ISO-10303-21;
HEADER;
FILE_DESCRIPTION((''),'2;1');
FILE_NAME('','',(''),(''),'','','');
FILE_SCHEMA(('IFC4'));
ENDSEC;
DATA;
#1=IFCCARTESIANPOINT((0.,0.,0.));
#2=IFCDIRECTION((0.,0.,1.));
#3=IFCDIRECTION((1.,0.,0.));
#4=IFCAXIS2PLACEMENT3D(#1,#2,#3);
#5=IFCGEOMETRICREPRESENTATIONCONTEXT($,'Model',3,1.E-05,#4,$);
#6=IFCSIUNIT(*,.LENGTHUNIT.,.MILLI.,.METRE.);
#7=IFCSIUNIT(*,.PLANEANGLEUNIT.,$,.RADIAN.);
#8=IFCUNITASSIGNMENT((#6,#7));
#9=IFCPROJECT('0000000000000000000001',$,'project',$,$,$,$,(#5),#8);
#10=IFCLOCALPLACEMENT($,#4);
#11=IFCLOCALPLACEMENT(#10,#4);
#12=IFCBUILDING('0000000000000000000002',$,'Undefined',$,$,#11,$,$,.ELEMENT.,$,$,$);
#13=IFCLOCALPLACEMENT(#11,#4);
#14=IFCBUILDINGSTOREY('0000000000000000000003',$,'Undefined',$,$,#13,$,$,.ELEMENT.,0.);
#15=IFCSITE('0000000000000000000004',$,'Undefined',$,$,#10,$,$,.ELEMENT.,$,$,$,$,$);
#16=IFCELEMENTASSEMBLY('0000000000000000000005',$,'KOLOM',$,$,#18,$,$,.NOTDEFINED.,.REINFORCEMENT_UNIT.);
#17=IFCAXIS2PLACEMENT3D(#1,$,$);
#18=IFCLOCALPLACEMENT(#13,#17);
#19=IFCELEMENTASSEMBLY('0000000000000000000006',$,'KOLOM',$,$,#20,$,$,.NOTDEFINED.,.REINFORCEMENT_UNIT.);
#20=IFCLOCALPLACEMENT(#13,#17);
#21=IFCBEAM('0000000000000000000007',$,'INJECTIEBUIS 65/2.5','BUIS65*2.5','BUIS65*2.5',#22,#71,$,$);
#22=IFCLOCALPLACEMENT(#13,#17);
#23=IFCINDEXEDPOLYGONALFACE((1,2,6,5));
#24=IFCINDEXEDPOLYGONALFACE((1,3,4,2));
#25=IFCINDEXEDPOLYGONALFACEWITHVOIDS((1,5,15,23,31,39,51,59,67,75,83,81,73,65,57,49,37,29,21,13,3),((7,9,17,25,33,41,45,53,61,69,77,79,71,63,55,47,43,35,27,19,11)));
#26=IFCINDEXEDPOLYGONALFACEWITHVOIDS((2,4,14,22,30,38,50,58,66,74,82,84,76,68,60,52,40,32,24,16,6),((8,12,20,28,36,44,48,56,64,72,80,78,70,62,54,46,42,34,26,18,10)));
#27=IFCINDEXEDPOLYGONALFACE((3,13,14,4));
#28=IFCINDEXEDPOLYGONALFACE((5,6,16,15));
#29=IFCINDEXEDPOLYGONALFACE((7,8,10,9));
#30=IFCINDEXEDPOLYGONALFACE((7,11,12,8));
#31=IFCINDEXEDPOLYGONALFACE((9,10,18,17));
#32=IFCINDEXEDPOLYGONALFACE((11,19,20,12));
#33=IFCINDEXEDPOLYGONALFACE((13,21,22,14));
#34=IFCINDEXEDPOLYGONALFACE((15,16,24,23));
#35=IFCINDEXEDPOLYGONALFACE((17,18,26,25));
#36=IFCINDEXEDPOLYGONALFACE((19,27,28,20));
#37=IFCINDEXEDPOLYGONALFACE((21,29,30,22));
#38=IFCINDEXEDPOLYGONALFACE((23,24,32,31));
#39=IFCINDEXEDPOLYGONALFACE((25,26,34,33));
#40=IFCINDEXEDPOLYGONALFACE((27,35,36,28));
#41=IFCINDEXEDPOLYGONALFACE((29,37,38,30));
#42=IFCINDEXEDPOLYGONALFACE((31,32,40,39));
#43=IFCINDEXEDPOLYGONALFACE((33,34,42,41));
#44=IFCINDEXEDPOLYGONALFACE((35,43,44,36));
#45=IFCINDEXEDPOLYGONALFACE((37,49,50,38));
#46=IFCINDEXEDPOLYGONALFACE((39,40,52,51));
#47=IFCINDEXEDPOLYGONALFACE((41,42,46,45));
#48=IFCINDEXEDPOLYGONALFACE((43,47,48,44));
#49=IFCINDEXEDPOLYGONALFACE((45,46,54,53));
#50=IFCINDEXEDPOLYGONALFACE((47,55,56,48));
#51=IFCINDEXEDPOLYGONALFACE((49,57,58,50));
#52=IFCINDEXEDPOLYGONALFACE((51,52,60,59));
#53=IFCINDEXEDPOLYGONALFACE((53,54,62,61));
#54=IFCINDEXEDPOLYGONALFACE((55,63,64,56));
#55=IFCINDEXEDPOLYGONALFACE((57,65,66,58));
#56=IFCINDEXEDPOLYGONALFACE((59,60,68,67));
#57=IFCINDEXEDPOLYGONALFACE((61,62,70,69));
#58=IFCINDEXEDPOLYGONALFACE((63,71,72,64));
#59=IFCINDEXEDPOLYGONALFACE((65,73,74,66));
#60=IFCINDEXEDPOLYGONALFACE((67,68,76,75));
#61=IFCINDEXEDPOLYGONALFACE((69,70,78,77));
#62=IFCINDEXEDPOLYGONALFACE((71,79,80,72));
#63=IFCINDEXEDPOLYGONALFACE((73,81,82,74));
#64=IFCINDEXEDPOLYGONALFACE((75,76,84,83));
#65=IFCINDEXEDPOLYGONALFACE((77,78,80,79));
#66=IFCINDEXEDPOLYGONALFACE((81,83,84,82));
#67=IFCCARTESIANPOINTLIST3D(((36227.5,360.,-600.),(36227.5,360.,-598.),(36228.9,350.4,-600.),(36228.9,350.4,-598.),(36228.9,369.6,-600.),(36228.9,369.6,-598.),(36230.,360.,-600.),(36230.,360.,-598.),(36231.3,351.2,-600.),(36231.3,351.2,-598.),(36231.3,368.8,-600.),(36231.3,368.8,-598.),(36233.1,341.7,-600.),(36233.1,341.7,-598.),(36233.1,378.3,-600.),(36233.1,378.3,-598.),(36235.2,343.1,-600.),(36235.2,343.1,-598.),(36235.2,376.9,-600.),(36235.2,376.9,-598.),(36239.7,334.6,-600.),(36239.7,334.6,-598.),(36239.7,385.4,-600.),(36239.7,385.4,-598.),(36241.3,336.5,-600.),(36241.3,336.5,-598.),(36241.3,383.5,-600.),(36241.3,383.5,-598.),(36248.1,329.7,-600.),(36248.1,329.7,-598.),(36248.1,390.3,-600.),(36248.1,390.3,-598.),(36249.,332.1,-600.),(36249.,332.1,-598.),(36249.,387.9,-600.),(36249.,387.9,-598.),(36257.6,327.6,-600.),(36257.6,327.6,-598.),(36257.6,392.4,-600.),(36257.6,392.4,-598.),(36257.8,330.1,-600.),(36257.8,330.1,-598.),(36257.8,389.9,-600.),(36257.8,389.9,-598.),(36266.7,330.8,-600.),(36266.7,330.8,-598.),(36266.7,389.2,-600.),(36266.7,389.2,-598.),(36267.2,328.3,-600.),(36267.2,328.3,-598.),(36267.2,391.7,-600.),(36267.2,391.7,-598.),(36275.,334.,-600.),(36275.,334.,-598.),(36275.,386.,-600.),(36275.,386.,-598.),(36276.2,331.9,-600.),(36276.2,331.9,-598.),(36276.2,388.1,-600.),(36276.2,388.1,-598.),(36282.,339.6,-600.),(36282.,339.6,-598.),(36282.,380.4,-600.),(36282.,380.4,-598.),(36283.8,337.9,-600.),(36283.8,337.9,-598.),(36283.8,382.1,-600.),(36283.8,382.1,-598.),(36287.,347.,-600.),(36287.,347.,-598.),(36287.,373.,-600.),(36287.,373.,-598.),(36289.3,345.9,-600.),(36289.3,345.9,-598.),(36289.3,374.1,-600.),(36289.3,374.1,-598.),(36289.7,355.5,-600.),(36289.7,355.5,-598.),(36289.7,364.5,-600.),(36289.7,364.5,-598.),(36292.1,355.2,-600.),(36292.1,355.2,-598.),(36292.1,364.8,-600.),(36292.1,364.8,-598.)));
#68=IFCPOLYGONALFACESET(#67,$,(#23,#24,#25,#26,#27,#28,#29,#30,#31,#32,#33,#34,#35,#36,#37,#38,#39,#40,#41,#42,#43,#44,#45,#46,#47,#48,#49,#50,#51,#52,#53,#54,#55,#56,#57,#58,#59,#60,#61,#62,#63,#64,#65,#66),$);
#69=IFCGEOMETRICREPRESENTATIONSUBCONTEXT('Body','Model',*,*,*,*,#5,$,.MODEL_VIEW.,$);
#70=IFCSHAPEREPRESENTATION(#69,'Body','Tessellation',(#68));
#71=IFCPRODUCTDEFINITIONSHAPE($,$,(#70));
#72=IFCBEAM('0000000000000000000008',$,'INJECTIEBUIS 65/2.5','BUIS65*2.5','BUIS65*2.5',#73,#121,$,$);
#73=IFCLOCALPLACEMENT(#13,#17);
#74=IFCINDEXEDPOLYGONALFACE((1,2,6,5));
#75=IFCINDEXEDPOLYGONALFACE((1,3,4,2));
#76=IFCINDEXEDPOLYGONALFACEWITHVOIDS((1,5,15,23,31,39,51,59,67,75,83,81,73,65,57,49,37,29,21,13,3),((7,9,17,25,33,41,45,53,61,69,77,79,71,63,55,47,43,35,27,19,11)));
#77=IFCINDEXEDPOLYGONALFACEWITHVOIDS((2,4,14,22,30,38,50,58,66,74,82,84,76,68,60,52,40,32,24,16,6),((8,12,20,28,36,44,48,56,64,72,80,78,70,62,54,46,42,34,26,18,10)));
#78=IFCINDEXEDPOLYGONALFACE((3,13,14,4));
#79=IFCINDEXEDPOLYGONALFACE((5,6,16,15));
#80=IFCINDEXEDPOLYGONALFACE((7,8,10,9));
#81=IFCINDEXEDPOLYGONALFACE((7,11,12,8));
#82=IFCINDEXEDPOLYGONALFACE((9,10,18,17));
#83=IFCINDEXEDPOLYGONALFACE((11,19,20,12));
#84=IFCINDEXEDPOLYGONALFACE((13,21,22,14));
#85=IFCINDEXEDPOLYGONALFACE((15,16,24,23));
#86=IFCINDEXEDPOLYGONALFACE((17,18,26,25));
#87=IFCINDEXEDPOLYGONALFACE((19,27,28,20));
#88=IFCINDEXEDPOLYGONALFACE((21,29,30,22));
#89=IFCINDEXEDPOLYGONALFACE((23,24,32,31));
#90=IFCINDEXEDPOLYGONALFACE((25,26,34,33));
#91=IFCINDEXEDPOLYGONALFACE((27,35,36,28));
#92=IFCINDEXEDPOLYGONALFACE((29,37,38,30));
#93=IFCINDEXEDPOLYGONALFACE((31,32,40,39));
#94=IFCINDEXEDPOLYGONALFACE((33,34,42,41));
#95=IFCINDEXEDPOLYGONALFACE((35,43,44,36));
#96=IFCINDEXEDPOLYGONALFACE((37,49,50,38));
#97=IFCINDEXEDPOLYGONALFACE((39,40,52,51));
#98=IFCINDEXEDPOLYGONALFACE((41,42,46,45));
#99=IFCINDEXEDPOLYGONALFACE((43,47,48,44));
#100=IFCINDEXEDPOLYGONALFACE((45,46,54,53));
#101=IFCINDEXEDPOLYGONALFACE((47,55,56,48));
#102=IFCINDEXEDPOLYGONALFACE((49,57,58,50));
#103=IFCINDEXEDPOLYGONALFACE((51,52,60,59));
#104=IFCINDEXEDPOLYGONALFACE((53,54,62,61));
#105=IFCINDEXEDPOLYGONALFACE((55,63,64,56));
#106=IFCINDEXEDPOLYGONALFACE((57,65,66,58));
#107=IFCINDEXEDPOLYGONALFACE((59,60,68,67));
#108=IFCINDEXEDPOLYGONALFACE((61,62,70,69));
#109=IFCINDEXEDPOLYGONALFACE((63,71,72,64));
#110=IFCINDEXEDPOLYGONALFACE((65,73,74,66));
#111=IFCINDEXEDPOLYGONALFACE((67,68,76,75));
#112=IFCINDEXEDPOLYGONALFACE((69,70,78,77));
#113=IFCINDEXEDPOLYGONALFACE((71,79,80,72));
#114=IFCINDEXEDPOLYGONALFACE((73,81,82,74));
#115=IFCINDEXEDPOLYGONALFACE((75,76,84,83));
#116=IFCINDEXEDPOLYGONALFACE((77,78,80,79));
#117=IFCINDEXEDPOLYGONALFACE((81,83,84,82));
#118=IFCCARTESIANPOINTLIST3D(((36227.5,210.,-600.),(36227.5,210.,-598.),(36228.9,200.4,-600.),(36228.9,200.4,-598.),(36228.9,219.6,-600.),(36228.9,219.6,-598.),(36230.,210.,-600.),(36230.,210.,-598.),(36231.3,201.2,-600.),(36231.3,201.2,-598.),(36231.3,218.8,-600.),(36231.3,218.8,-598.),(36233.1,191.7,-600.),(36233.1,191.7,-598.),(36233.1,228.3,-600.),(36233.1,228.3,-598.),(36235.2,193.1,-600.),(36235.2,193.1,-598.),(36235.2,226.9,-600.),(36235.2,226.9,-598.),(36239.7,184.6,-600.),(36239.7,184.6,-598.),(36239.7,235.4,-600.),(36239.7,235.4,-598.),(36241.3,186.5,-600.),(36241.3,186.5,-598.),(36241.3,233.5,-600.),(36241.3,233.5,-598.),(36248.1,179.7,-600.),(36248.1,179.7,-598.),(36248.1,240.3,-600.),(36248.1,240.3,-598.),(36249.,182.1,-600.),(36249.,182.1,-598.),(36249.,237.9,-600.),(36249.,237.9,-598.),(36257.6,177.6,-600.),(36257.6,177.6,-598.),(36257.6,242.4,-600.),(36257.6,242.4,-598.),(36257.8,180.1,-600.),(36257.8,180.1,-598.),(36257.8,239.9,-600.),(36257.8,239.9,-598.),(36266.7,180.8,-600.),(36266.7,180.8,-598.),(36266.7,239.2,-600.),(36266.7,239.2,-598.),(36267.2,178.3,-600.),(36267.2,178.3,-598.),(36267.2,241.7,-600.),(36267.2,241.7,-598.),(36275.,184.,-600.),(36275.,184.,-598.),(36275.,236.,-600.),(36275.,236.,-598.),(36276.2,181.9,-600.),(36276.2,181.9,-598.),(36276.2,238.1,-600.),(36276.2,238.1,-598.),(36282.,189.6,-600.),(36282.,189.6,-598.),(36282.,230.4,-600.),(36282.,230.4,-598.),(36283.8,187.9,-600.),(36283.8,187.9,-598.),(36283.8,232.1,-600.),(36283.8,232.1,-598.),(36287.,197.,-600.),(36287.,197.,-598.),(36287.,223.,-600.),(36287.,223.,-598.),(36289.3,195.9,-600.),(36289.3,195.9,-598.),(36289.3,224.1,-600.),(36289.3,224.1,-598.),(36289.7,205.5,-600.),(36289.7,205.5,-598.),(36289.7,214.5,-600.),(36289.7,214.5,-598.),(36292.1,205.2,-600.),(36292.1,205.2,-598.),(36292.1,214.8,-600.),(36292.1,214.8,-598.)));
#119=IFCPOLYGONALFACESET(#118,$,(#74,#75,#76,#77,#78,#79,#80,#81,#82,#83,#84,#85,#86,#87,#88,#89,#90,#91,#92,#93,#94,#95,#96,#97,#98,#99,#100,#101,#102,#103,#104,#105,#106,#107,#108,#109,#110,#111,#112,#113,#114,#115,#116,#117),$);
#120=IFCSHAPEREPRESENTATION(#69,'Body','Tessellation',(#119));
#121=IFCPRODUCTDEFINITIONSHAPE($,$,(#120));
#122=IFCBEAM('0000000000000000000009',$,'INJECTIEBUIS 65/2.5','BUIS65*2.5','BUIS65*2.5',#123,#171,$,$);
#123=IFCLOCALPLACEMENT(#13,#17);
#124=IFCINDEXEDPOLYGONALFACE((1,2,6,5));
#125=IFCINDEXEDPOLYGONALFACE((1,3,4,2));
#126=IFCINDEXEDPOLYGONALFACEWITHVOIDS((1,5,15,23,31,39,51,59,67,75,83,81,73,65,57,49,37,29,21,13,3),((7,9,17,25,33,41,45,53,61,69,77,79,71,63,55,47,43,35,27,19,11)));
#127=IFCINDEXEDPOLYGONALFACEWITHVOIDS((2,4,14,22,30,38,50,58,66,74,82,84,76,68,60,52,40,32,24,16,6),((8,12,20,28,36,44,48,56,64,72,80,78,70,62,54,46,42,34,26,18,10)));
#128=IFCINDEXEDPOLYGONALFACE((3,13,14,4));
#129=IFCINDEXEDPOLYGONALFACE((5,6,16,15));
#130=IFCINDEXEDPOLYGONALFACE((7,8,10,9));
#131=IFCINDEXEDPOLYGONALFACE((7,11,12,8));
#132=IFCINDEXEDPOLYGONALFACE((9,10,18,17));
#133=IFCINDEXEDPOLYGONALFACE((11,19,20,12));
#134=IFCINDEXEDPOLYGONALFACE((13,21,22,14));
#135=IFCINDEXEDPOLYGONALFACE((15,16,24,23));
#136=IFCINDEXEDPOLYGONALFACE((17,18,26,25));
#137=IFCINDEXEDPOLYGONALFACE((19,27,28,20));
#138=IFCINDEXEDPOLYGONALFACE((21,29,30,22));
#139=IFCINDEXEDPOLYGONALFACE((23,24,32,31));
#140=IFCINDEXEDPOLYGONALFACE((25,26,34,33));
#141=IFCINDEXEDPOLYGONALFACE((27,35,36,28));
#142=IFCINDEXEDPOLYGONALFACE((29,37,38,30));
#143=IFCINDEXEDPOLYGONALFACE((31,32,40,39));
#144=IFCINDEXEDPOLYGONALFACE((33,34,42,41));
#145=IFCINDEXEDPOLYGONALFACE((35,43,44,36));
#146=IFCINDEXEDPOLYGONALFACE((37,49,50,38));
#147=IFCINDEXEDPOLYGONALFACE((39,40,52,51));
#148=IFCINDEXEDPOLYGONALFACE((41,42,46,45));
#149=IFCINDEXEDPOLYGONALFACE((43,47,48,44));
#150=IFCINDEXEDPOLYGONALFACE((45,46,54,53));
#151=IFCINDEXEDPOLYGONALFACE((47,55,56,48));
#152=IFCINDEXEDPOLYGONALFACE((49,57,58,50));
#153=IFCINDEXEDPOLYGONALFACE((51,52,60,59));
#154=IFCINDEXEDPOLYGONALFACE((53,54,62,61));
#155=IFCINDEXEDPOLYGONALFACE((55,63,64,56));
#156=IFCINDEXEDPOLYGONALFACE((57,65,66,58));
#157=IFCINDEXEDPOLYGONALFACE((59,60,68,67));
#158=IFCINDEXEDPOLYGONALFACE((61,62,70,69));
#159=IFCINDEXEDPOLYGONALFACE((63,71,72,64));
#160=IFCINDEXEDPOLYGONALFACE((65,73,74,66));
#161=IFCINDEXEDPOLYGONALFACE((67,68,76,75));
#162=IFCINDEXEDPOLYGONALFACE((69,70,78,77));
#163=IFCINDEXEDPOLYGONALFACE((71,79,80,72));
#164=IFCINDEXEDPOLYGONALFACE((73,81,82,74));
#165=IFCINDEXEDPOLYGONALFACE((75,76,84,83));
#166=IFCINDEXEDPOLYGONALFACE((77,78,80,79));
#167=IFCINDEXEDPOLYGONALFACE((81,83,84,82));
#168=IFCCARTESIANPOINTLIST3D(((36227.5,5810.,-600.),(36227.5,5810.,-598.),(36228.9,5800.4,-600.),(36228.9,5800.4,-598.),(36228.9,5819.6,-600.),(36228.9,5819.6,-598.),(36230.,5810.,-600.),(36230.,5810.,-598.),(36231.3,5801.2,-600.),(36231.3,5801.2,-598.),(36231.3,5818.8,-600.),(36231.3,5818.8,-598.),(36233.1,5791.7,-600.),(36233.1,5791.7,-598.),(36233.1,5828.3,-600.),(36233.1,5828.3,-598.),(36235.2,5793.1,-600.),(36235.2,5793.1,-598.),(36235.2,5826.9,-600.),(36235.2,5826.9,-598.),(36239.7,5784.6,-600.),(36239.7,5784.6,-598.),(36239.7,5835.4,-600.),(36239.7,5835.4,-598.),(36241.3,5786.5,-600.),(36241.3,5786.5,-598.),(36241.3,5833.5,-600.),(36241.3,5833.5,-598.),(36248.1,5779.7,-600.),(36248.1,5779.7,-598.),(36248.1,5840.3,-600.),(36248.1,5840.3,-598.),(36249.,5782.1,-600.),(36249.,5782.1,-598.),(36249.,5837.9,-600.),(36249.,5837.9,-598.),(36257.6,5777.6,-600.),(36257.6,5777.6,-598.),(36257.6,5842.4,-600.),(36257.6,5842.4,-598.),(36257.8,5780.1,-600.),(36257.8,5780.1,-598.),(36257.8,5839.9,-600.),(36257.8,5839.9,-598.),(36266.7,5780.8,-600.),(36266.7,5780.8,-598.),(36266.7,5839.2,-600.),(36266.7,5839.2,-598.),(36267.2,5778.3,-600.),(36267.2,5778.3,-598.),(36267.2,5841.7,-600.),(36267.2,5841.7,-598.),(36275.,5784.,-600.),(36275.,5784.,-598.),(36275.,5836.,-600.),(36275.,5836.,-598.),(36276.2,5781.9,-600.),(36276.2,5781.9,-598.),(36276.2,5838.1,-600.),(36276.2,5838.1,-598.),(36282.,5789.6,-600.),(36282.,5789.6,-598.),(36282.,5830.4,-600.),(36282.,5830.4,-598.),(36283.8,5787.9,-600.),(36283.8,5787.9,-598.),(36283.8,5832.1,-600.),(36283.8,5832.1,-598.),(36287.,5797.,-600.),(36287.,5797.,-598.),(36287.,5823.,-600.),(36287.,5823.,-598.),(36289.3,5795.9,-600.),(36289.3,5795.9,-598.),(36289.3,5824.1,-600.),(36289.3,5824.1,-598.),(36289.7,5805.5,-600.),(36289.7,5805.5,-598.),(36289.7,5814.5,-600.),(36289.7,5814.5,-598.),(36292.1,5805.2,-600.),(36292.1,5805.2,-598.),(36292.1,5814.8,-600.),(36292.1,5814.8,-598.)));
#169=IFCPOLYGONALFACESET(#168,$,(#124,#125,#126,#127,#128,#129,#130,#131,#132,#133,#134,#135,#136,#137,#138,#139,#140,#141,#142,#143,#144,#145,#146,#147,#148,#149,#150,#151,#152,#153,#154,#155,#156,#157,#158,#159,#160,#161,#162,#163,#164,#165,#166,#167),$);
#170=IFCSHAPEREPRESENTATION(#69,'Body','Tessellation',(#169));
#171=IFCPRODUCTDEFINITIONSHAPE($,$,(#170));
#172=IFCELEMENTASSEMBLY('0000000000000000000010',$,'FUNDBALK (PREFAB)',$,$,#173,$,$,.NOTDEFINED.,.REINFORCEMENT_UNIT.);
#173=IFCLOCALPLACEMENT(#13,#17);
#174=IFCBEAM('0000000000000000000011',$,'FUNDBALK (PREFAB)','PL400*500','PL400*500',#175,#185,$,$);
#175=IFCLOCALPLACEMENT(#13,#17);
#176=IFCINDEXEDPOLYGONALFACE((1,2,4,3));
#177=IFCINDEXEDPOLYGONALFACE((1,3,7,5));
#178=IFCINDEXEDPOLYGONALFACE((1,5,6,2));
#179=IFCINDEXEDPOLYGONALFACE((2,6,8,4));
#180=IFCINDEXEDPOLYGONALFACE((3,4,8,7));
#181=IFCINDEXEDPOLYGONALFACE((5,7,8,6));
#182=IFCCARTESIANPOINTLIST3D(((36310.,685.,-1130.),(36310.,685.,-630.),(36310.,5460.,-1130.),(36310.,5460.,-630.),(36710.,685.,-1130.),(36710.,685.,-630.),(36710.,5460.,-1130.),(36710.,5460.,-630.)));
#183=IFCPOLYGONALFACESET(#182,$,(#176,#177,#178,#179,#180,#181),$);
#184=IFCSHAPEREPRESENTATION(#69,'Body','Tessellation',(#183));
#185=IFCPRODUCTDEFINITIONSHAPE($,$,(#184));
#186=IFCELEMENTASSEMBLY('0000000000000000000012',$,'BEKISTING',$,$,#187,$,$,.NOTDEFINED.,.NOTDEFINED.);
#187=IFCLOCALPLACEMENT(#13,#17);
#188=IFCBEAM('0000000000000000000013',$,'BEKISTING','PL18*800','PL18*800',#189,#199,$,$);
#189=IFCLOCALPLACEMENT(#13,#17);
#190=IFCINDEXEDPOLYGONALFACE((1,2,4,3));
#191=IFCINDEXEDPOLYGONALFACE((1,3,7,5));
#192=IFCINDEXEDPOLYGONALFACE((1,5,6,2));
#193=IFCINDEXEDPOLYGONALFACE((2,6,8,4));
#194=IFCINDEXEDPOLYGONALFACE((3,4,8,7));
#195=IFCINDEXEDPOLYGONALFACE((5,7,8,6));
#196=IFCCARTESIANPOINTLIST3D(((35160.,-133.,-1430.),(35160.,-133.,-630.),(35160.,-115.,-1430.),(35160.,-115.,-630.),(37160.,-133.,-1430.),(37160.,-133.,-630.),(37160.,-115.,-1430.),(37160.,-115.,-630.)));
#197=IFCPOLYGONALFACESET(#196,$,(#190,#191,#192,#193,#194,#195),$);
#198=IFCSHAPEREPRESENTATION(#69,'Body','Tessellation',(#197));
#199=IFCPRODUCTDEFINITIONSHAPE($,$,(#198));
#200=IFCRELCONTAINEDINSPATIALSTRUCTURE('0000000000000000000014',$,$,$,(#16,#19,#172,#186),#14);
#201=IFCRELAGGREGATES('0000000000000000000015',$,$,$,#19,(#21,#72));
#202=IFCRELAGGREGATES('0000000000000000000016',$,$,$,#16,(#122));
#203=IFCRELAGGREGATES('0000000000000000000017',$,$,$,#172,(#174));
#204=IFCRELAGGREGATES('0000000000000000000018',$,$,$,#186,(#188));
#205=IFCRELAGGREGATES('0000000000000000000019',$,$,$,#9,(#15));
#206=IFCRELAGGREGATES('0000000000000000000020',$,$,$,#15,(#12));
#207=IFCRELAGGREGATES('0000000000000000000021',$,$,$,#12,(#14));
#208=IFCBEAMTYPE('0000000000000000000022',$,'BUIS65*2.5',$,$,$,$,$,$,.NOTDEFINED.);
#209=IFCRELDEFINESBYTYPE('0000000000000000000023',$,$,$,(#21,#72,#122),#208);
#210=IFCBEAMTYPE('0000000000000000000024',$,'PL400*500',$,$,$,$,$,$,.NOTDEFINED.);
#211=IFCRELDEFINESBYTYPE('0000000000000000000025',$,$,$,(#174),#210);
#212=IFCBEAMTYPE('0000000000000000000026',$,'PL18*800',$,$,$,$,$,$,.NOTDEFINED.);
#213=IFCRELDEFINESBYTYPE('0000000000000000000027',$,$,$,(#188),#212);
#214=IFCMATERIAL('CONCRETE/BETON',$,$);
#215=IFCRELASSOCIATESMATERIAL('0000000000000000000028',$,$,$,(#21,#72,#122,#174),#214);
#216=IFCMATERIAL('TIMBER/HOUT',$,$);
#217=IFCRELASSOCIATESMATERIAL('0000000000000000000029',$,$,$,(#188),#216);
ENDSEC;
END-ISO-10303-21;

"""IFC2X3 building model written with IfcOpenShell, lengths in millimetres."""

from ifc_helpers import new_model, si_unit, frame, frame_2d, origin_with_axes, place, context, subcontext, project, spatial, rectangle, hollow_circle, extrude, material, type_object, element, aggregate, save


model = new_model("IFC2X3")

# Units and contexts
model_context = context("Model", 3, precision=1e-05, world=origin_with_axes())
body_context = subcontext(model_context, "Body", "Model", "MODEL_VIEW")
ifc_project = project(units=[si_unit("LENGTHUNIT", "METRE", prefix="MILLI"), si_unit("PLANEANGLEUNIT", "RADIAN")], contexts=[model_context])

# Site, building, storey
site_placement = place(None, origin_with_axes())
site = spatial("IfcSite", under=ifc_project, at=site_placement, Name="Undefined", CompositionType="ELEMENT")
building_placement = place(site_placement, origin_with_axes())
building = spatial("IfcBuilding", under=site, at=building_placement, Name="Undefined", CompositionType="ELEMENT")
storey_placement = place(building_placement, origin_with_axes())
storey = spatial("IfcBuildingStorey", under=building, at=storey_placement, Name="Undefined", CompositionType="ELEMENT", Elevation=0.0)

# Element assembly
ifc_material_1 = material(Name="CONCRETE/BETON")
assembly_1_placement = place(storey_placement, origin_with_axes())
assembly_1 = element("IfcElementAssembly", 1, at=assembly_1_placement, inside=storey, Name="KOLOM", AssemblyPlace="NOTDEFINED", PredefinedType="REINFORCEMENT_UNIT")

# Element assembly, beams
assembly_2_placement = place(storey_placement, origin_with_axes())
assembly_2 = element("IfcElementAssembly", 2, at=assembly_2_placement, inside=storey, Name="KOLOM", AssemblyPlace="NOTDEFINED", PredefinedType="REINFORCEMENT_UNIT")
beam_type_1 = type_object("IfcBeamType", Name="BUIS65*2.5", PredefinedType="NOTDEFINED")
beam_1_placement = place(assembly_2_placement, frame((36260.0, 360.0, -600.0), z_axis=(0.0, 1.0, 0.0), x_axis=(0.0, 0.0, 1.0)))
beam_1 = element("IfcBeam", 3, at=beam_1_placement, type_object=beam_type_1, material=ifc_material_1, Name="INJECTIEBUIS 65/2.5", Description="BUIS65*2.5", ObjectType="BUIS65*2.5", context=body_context, shape_type="SweptSolid", body=[
    extrude(hollow_circle(Radius=32.5, WallThickness=2.5, at=frame_2d((0.0, 0.0), x_axis=(1.0, 0.0))), frame((2.0, 0.0, 0.0), z_axis=(-1.0, 0.0, 0.0), x_axis=(0.0, -1.0, 0.0)), (0.0, 0.0, 1.0), 2.0),
])
beam_2_placement = place(assembly_2_placement, frame((36260.0, 210.0, -600.0), z_axis=(0.0, 1.0, 0.0), x_axis=(0.0, 0.0, 1.0)))
beam_2 = element("IfcBeam", 4, at=beam_2_placement, type_object=beam_type_1, material=ifc_material_1, Name="INJECTIEBUIS 65/2.5", Description="BUIS65*2.5", ObjectType="BUIS65*2.5", context=body_context, shape_type="SweptSolid", body=[
    extrude(hollow_circle(Radius=32.5, WallThickness=2.5, at=frame_2d((0.0, 0.0), x_axis=(1.0, 0.0))), frame((2.0, 0.0, 0.0), z_axis=(-1.0, 0.0, 0.0), x_axis=(0.0, -1.0, 0.0)), (0.0, 0.0, 1.0), 2.0),
])
aggregate(assembly_2, [beam_1, beam_2])

# Beam
beam_3_placement = place(assembly_1_placement, frame((36260.0, 5810.0, -600.0), z_axis=(0.0, 1.0, 0.0), x_axis=(0.0, 0.0, 1.0)))
beam_3 = element("IfcBeam", 5, at=beam_3_placement, type_object=beam_type_1, material=ifc_material_1, Name="INJECTIEBUIS 65/2.5", Description="BUIS65*2.5", ObjectType="BUIS65*2.5", context=body_context, shape_type="SweptSolid", body=[
    extrude(hollow_circle(Radius=32.5, WallThickness=2.5, at=frame_2d((0.0, 0.0), x_axis=(1.0, 0.0))), frame((2.0, 0.0, 0.0), z_axis=(-1.0, 0.0, 0.0), x_axis=(0.0, -1.0, 0.0)), (0.0, 0.0, 1.0), 2.0),
])
aggregate(assembly_1, [beam_3])

# Element assemblies, beams
assembly_3_placement = place(storey_placement, origin_with_axes())
assembly_3 = element("IfcElementAssembly", 6, at=assembly_3_placement, inside=storey, Name="FUNDBALK (PREFAB)", AssemblyPlace="NOTDEFINED", PredefinedType="REINFORCEMENT_UNIT")
beam_type_2 = type_object("IfcBeamType", Name="PL400*500", PredefinedType="NOTDEFINED")
beam_4_placement = place(assembly_3_placement, frame((36510.0, 5460.0, -880.0), z_axis=(0.0, 0.0, 1.0), x_axis=(0.0, -1.0, 0.0)))
beam_4 = element("IfcBeam", 7, at=beam_4_placement, type_object=beam_type_2, material=ifc_material_1, Name="FUNDBALK (PREFAB)", Description="PL400*500", ObjectType="PL400*500", context=body_context, shape_type="SweptSolid", body=[
    extrude(rectangle(XDim=400.0, YDim=500.0, at=frame_2d((0.0, 0.0), x_axis=(1.0, 0.0))), frame((4775.0, 0.0, 0.0), z_axis=(-1.0, 0.0, 0.0), x_axis=(0.0, -1.0, 0.0)), (0.0, 0.0, 1.0), 4775.0),
])
aggregate(assembly_3, [beam_4])
assembly_4_placement = place(storey_placement, origin_with_axes())
assembly_4 = element("IfcElementAssembly", 8, at=assembly_4_placement, inside=storey, Name="BEKISTING", AssemblyPlace="NOTDEFINED", PredefinedType="NOTDEFINED")
ifc_material_2 = material(Name="TIMBER/HOUT")
beam_type_3 = type_object("IfcBeamType", Name="PL18*800", PredefinedType="NOTDEFINED")
beam_5_placement = place(assembly_4_placement, frame((37160.0, -124.0, -1030.0), z_axis=(0.0, 0.0, -1.0), x_axis=(-1.0, 0.0, 0.0)))
beam_5 = element("IfcBeam", 9, at=beam_5_placement, type_object=beam_type_3, material=ifc_material_2, Name="BEKISTING", Description="PL18*800", ObjectType="PL18*800", context=body_context, shape_type="SweptSolid", body=[
    extrude(rectangle(XDim=18.0, YDim=800.0, at=frame_2d((0.0, 0.0), x_axis=(1.0, 0.0))), frame((2000.0, 0.0, 0.0), z_axis=(-1.0, 0.0, 0.0), x_axis=(0.0, -1.0, 0.0)), (0.0, 0.0, 1.0), 2000.0),
])
aggregate(assembly_4, [beam_5])

save(model, "model.ifc")
